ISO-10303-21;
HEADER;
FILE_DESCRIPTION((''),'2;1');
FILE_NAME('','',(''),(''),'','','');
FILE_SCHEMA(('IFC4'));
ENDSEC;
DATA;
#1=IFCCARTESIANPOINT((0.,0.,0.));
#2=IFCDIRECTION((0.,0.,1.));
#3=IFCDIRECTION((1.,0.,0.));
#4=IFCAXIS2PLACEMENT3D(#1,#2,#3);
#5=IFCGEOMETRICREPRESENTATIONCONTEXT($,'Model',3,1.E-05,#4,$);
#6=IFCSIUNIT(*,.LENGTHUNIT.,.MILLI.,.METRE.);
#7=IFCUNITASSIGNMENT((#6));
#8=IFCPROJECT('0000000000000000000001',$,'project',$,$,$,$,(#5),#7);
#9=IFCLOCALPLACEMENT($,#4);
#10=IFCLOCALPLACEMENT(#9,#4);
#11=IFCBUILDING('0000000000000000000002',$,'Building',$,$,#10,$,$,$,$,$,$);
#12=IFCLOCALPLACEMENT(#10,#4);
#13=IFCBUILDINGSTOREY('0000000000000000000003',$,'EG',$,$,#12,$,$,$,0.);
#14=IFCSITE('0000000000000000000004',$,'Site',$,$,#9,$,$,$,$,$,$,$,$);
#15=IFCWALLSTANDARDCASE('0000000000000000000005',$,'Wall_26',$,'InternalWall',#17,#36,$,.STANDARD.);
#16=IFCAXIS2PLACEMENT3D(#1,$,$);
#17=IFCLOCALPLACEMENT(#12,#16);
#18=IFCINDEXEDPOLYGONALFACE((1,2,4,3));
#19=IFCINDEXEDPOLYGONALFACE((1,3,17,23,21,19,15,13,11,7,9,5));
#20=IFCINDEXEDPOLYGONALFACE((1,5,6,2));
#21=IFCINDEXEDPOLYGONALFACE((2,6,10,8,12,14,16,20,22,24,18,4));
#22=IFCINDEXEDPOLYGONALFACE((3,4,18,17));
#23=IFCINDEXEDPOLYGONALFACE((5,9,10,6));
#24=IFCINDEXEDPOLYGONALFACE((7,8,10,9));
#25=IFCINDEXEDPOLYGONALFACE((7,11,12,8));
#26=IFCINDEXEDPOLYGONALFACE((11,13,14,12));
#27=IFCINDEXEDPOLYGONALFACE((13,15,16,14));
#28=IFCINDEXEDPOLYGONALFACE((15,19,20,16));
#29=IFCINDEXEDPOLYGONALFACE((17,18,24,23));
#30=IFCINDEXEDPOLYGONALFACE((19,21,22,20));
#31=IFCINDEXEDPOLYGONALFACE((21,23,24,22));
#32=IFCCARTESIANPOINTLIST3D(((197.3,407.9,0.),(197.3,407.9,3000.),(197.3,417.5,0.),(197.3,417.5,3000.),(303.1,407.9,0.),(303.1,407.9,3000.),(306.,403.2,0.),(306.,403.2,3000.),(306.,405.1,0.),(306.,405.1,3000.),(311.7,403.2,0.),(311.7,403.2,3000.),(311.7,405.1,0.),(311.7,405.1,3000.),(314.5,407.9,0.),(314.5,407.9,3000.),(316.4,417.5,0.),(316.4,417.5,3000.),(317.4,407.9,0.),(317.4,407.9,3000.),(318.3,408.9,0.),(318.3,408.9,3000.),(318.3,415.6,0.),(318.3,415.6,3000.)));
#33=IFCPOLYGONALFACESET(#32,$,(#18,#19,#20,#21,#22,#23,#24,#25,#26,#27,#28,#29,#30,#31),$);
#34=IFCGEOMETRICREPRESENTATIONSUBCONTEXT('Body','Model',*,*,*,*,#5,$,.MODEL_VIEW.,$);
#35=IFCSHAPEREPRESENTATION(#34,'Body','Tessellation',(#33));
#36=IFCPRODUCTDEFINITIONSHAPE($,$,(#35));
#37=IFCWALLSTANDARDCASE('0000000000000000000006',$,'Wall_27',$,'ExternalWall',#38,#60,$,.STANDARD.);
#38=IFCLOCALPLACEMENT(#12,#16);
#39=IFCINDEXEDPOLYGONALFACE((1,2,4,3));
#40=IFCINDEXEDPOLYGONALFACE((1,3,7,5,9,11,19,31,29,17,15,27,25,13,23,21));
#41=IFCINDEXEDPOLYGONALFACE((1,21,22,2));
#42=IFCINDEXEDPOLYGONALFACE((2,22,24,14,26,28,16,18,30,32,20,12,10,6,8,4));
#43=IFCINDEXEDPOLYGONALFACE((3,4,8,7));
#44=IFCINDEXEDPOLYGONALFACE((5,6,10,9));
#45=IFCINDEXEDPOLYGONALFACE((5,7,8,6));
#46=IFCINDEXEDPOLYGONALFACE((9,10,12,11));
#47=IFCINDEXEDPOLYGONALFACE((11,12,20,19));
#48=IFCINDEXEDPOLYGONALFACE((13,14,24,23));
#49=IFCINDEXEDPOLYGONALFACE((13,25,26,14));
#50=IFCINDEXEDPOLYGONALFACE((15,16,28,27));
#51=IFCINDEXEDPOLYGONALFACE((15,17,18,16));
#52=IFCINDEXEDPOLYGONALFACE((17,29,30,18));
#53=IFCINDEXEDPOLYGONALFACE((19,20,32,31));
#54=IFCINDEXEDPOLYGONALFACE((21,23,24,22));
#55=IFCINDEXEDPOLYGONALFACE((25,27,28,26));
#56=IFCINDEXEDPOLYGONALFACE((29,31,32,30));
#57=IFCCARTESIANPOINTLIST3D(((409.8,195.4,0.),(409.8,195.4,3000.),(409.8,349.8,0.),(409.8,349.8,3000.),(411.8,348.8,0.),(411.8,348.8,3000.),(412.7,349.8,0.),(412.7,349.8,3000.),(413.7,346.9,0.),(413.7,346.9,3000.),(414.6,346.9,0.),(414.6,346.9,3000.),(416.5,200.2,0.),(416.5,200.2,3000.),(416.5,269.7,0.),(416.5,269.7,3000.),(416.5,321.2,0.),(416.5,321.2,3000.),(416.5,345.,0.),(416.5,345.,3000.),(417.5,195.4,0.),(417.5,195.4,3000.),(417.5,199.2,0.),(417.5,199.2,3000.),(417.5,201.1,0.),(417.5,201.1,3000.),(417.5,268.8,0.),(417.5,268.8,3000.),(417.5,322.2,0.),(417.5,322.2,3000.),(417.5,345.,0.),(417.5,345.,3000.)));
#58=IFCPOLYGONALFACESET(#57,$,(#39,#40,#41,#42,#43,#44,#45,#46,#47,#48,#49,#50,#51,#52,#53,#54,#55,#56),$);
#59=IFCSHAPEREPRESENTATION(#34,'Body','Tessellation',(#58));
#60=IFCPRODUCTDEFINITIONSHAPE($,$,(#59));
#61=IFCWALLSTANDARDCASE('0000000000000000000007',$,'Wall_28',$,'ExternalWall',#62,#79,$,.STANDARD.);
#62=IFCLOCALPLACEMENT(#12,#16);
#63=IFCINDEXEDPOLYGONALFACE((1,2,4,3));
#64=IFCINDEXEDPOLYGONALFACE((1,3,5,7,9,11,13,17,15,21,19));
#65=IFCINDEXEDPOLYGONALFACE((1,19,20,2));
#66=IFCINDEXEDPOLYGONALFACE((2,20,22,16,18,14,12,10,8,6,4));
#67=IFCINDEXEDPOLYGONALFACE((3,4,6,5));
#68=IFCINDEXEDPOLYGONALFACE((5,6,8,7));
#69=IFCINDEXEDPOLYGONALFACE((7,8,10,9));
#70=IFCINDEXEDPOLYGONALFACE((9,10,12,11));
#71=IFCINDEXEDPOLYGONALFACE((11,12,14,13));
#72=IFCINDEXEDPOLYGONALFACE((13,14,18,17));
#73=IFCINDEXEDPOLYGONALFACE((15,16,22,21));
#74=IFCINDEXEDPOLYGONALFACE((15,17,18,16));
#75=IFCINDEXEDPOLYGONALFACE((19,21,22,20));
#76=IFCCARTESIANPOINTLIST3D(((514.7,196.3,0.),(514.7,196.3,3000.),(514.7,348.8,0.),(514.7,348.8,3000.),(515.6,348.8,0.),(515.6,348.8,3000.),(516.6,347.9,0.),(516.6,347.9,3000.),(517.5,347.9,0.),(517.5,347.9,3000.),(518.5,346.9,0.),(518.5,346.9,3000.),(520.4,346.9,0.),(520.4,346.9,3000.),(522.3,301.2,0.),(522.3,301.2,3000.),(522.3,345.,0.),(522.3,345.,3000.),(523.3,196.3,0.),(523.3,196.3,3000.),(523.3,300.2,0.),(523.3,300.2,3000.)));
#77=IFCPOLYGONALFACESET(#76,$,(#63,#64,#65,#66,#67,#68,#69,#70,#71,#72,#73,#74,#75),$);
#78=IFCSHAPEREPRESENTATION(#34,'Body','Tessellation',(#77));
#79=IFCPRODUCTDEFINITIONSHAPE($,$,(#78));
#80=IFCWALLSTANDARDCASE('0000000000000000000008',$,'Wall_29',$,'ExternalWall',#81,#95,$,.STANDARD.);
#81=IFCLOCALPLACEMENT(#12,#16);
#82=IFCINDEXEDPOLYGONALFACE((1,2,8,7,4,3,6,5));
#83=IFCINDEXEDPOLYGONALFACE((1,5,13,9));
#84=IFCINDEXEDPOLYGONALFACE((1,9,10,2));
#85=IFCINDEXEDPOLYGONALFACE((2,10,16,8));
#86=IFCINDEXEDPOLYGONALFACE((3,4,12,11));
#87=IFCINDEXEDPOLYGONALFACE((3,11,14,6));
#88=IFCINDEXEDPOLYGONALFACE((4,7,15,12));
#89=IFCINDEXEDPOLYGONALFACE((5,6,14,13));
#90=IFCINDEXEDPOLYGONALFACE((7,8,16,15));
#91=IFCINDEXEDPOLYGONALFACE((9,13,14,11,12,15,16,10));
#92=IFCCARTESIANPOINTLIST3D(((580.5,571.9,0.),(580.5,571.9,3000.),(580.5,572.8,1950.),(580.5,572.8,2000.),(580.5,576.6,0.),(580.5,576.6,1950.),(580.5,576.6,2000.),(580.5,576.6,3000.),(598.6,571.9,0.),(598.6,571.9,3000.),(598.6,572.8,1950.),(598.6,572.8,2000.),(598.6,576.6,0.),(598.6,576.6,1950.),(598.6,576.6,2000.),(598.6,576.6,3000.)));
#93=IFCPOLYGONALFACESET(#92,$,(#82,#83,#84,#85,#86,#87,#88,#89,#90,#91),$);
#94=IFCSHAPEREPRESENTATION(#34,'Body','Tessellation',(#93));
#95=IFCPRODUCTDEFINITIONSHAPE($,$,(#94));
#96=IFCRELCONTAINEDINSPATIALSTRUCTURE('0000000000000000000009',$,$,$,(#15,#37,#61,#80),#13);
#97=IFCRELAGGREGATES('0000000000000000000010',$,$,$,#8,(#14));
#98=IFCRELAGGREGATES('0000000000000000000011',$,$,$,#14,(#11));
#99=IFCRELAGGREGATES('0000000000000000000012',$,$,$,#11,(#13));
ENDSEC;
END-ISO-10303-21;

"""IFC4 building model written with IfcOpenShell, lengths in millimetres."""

from ifc_helpers import new_model, si_unit, frame, origin_with_axes, place, context, subcontext, project, spatial, polyline, rectangle, outline, extrude, element, save


model = new_model("IFC4")

# Units and contexts
model_context = context("Model", 3, precision=1e-05, world=origin_with_axes())
body_context = subcontext(model_context, "Body", "Model", "MODEL_VIEW")
ifc_project = project(units=[si_unit("LENGTHUNIT", "METRE", prefix="MILLI")], contexts=[model_context])

# Site, building, storey
site_placement = place(None, origin_with_axes())
site = spatial("IfcSite", under=ifc_project, at=site_placement, Name="Site")
building_placement = place(site_placement, origin_with_axes())
building = spatial("IfcBuilding", under=site, at=building_placement, Name="Building")
storey_placement = place(building_placement, origin_with_axes())
storey = spatial("IfcBuildingStorey", under=building, at=storey_placement, Name="EG", Elevation=0.0)

# Walls
wall_1_placement = place(storey_placement, origin_with_axes())
element("IfcWallStandardCase", 1, at=wall_1_placement, inside=storey, Name="Wall_26", ObjectType="InternalWall", PredefinedType="STANDARD", context=body_context, shape_type="SweptSolid", body=[
    extrude(outline(polyline([(306.0, 403.2, 0.0), (306.0, 405.1, 0.0), (303.1, 407.9, 0.0), (197.3, 407.9, 0.0), (197.3, 417.5, 0.0), (316.4, 417.5, 0.0), (318.3, 415.6, 0.0), (318.3, 408.9, 0.0), (317.4, 407.9, 0.0), (314.5, 407.9, 0.0), (311.7, 405.1, 0.0), (311.7, 403.2, 0.0), (306.0, 403.2, 0.0)])), origin_with_axes(), (0.0, 0.0, 1.0), 3000.0),
])
wall_2_placement = place(storey_placement, origin_with_axes())
element("IfcWallStandardCase", 2, at=wall_2_placement, inside=storey, Name="Wall_27", ObjectType="ExternalWall", PredefinedType="STANDARD", context=body_context, shape_type="SweptSolid", body=[
    extrude(outline(polyline([(409.8, 195.4, 0.0), (409.8, 349.8, 0.0), (412.7, 349.8, 0.0), (411.8, 348.8, 0.0), (413.7, 346.9, 0.0), (414.6, 346.9, 0.0), (416.5, 345.0, 0.0), (417.5, 345.0, 0.0), (417.5, 322.2, 0.0), (416.5, 321.2, 0.0), (416.5, 269.7, 0.0), (417.5, 268.8, 0.0), (417.5, 201.1, 0.0), (416.5, 200.2, 0.0), (417.5, 199.2, 0.0), (417.5, 195.4, 0.0), (409.8, 195.4, 0.0)])), origin_with_axes(), (0.0, 0.0, 1.0), 3000.0),
])
wall_3_placement = place(storey_placement, origin_with_axes())
element("IfcWallStandardCase", 3, at=wall_3_placement, inside=storey, Name="Wall_28", ObjectType="ExternalWall", PredefinedType="STANDARD", context=body_context, shape_type="SweptSolid", body=[
    extrude(outline(polyline([(514.7, 196.3, 0.0), (514.7, 348.8, 0.0), (515.6, 348.8, 0.0), (516.6, 347.9, 0.0), (517.5, 347.9, 0.0), (518.5, 346.9, 0.0), (520.4, 346.9, 0.0), (522.3, 345.0, 0.0), (522.3, 301.2, 0.0), (523.3, 300.2, 0.0), (523.3, 196.3, 0.0), (514.7, 196.3, 0.0)])), origin_with_axes(), (0.0, 0.0, 1.0), 3000.0),
])

# Wall, opening
wall_4_placement = place(storey_placement, origin_with_axes())
wall_4 = element("IfcWallStandardCase", 4, at=wall_4_placement, inside=storey, Name="Wall_29", ObjectType="ExternalWall", PredefinedType="STANDARD", context=body_context, shape_type="SweptSolid", body=[
    extrude(outline(polyline([(580.5, 571.9, 0.0), (580.5, 576.6, 0.0), (598.6, 576.6, 0.0), (598.6, 571.9, 0.0), (580.5, 571.9, 0.0)])), origin_with_axes(), (0.0, 0.0, 1.0), 3000.0),
])
opening_1_placement = place(wall_4_placement, origin_with_axes())
element("IfcOpeningElement", 5, at=opening_1_placement, inside=storey, cuts=wall_4, context=body_context, shape_type="SweptSolid", body=[
    extrude(rectangle(XDim=1200.0, YDim=4.8), frame((560.4, 575.2, 1950.0), z_axis=(0.0, 0.0, 1.0), x_axis=(1.0, 0.0, 0.0)), (0.0, 0.0, 1.0), 50.0),
])

save(model, "model.ifc")
